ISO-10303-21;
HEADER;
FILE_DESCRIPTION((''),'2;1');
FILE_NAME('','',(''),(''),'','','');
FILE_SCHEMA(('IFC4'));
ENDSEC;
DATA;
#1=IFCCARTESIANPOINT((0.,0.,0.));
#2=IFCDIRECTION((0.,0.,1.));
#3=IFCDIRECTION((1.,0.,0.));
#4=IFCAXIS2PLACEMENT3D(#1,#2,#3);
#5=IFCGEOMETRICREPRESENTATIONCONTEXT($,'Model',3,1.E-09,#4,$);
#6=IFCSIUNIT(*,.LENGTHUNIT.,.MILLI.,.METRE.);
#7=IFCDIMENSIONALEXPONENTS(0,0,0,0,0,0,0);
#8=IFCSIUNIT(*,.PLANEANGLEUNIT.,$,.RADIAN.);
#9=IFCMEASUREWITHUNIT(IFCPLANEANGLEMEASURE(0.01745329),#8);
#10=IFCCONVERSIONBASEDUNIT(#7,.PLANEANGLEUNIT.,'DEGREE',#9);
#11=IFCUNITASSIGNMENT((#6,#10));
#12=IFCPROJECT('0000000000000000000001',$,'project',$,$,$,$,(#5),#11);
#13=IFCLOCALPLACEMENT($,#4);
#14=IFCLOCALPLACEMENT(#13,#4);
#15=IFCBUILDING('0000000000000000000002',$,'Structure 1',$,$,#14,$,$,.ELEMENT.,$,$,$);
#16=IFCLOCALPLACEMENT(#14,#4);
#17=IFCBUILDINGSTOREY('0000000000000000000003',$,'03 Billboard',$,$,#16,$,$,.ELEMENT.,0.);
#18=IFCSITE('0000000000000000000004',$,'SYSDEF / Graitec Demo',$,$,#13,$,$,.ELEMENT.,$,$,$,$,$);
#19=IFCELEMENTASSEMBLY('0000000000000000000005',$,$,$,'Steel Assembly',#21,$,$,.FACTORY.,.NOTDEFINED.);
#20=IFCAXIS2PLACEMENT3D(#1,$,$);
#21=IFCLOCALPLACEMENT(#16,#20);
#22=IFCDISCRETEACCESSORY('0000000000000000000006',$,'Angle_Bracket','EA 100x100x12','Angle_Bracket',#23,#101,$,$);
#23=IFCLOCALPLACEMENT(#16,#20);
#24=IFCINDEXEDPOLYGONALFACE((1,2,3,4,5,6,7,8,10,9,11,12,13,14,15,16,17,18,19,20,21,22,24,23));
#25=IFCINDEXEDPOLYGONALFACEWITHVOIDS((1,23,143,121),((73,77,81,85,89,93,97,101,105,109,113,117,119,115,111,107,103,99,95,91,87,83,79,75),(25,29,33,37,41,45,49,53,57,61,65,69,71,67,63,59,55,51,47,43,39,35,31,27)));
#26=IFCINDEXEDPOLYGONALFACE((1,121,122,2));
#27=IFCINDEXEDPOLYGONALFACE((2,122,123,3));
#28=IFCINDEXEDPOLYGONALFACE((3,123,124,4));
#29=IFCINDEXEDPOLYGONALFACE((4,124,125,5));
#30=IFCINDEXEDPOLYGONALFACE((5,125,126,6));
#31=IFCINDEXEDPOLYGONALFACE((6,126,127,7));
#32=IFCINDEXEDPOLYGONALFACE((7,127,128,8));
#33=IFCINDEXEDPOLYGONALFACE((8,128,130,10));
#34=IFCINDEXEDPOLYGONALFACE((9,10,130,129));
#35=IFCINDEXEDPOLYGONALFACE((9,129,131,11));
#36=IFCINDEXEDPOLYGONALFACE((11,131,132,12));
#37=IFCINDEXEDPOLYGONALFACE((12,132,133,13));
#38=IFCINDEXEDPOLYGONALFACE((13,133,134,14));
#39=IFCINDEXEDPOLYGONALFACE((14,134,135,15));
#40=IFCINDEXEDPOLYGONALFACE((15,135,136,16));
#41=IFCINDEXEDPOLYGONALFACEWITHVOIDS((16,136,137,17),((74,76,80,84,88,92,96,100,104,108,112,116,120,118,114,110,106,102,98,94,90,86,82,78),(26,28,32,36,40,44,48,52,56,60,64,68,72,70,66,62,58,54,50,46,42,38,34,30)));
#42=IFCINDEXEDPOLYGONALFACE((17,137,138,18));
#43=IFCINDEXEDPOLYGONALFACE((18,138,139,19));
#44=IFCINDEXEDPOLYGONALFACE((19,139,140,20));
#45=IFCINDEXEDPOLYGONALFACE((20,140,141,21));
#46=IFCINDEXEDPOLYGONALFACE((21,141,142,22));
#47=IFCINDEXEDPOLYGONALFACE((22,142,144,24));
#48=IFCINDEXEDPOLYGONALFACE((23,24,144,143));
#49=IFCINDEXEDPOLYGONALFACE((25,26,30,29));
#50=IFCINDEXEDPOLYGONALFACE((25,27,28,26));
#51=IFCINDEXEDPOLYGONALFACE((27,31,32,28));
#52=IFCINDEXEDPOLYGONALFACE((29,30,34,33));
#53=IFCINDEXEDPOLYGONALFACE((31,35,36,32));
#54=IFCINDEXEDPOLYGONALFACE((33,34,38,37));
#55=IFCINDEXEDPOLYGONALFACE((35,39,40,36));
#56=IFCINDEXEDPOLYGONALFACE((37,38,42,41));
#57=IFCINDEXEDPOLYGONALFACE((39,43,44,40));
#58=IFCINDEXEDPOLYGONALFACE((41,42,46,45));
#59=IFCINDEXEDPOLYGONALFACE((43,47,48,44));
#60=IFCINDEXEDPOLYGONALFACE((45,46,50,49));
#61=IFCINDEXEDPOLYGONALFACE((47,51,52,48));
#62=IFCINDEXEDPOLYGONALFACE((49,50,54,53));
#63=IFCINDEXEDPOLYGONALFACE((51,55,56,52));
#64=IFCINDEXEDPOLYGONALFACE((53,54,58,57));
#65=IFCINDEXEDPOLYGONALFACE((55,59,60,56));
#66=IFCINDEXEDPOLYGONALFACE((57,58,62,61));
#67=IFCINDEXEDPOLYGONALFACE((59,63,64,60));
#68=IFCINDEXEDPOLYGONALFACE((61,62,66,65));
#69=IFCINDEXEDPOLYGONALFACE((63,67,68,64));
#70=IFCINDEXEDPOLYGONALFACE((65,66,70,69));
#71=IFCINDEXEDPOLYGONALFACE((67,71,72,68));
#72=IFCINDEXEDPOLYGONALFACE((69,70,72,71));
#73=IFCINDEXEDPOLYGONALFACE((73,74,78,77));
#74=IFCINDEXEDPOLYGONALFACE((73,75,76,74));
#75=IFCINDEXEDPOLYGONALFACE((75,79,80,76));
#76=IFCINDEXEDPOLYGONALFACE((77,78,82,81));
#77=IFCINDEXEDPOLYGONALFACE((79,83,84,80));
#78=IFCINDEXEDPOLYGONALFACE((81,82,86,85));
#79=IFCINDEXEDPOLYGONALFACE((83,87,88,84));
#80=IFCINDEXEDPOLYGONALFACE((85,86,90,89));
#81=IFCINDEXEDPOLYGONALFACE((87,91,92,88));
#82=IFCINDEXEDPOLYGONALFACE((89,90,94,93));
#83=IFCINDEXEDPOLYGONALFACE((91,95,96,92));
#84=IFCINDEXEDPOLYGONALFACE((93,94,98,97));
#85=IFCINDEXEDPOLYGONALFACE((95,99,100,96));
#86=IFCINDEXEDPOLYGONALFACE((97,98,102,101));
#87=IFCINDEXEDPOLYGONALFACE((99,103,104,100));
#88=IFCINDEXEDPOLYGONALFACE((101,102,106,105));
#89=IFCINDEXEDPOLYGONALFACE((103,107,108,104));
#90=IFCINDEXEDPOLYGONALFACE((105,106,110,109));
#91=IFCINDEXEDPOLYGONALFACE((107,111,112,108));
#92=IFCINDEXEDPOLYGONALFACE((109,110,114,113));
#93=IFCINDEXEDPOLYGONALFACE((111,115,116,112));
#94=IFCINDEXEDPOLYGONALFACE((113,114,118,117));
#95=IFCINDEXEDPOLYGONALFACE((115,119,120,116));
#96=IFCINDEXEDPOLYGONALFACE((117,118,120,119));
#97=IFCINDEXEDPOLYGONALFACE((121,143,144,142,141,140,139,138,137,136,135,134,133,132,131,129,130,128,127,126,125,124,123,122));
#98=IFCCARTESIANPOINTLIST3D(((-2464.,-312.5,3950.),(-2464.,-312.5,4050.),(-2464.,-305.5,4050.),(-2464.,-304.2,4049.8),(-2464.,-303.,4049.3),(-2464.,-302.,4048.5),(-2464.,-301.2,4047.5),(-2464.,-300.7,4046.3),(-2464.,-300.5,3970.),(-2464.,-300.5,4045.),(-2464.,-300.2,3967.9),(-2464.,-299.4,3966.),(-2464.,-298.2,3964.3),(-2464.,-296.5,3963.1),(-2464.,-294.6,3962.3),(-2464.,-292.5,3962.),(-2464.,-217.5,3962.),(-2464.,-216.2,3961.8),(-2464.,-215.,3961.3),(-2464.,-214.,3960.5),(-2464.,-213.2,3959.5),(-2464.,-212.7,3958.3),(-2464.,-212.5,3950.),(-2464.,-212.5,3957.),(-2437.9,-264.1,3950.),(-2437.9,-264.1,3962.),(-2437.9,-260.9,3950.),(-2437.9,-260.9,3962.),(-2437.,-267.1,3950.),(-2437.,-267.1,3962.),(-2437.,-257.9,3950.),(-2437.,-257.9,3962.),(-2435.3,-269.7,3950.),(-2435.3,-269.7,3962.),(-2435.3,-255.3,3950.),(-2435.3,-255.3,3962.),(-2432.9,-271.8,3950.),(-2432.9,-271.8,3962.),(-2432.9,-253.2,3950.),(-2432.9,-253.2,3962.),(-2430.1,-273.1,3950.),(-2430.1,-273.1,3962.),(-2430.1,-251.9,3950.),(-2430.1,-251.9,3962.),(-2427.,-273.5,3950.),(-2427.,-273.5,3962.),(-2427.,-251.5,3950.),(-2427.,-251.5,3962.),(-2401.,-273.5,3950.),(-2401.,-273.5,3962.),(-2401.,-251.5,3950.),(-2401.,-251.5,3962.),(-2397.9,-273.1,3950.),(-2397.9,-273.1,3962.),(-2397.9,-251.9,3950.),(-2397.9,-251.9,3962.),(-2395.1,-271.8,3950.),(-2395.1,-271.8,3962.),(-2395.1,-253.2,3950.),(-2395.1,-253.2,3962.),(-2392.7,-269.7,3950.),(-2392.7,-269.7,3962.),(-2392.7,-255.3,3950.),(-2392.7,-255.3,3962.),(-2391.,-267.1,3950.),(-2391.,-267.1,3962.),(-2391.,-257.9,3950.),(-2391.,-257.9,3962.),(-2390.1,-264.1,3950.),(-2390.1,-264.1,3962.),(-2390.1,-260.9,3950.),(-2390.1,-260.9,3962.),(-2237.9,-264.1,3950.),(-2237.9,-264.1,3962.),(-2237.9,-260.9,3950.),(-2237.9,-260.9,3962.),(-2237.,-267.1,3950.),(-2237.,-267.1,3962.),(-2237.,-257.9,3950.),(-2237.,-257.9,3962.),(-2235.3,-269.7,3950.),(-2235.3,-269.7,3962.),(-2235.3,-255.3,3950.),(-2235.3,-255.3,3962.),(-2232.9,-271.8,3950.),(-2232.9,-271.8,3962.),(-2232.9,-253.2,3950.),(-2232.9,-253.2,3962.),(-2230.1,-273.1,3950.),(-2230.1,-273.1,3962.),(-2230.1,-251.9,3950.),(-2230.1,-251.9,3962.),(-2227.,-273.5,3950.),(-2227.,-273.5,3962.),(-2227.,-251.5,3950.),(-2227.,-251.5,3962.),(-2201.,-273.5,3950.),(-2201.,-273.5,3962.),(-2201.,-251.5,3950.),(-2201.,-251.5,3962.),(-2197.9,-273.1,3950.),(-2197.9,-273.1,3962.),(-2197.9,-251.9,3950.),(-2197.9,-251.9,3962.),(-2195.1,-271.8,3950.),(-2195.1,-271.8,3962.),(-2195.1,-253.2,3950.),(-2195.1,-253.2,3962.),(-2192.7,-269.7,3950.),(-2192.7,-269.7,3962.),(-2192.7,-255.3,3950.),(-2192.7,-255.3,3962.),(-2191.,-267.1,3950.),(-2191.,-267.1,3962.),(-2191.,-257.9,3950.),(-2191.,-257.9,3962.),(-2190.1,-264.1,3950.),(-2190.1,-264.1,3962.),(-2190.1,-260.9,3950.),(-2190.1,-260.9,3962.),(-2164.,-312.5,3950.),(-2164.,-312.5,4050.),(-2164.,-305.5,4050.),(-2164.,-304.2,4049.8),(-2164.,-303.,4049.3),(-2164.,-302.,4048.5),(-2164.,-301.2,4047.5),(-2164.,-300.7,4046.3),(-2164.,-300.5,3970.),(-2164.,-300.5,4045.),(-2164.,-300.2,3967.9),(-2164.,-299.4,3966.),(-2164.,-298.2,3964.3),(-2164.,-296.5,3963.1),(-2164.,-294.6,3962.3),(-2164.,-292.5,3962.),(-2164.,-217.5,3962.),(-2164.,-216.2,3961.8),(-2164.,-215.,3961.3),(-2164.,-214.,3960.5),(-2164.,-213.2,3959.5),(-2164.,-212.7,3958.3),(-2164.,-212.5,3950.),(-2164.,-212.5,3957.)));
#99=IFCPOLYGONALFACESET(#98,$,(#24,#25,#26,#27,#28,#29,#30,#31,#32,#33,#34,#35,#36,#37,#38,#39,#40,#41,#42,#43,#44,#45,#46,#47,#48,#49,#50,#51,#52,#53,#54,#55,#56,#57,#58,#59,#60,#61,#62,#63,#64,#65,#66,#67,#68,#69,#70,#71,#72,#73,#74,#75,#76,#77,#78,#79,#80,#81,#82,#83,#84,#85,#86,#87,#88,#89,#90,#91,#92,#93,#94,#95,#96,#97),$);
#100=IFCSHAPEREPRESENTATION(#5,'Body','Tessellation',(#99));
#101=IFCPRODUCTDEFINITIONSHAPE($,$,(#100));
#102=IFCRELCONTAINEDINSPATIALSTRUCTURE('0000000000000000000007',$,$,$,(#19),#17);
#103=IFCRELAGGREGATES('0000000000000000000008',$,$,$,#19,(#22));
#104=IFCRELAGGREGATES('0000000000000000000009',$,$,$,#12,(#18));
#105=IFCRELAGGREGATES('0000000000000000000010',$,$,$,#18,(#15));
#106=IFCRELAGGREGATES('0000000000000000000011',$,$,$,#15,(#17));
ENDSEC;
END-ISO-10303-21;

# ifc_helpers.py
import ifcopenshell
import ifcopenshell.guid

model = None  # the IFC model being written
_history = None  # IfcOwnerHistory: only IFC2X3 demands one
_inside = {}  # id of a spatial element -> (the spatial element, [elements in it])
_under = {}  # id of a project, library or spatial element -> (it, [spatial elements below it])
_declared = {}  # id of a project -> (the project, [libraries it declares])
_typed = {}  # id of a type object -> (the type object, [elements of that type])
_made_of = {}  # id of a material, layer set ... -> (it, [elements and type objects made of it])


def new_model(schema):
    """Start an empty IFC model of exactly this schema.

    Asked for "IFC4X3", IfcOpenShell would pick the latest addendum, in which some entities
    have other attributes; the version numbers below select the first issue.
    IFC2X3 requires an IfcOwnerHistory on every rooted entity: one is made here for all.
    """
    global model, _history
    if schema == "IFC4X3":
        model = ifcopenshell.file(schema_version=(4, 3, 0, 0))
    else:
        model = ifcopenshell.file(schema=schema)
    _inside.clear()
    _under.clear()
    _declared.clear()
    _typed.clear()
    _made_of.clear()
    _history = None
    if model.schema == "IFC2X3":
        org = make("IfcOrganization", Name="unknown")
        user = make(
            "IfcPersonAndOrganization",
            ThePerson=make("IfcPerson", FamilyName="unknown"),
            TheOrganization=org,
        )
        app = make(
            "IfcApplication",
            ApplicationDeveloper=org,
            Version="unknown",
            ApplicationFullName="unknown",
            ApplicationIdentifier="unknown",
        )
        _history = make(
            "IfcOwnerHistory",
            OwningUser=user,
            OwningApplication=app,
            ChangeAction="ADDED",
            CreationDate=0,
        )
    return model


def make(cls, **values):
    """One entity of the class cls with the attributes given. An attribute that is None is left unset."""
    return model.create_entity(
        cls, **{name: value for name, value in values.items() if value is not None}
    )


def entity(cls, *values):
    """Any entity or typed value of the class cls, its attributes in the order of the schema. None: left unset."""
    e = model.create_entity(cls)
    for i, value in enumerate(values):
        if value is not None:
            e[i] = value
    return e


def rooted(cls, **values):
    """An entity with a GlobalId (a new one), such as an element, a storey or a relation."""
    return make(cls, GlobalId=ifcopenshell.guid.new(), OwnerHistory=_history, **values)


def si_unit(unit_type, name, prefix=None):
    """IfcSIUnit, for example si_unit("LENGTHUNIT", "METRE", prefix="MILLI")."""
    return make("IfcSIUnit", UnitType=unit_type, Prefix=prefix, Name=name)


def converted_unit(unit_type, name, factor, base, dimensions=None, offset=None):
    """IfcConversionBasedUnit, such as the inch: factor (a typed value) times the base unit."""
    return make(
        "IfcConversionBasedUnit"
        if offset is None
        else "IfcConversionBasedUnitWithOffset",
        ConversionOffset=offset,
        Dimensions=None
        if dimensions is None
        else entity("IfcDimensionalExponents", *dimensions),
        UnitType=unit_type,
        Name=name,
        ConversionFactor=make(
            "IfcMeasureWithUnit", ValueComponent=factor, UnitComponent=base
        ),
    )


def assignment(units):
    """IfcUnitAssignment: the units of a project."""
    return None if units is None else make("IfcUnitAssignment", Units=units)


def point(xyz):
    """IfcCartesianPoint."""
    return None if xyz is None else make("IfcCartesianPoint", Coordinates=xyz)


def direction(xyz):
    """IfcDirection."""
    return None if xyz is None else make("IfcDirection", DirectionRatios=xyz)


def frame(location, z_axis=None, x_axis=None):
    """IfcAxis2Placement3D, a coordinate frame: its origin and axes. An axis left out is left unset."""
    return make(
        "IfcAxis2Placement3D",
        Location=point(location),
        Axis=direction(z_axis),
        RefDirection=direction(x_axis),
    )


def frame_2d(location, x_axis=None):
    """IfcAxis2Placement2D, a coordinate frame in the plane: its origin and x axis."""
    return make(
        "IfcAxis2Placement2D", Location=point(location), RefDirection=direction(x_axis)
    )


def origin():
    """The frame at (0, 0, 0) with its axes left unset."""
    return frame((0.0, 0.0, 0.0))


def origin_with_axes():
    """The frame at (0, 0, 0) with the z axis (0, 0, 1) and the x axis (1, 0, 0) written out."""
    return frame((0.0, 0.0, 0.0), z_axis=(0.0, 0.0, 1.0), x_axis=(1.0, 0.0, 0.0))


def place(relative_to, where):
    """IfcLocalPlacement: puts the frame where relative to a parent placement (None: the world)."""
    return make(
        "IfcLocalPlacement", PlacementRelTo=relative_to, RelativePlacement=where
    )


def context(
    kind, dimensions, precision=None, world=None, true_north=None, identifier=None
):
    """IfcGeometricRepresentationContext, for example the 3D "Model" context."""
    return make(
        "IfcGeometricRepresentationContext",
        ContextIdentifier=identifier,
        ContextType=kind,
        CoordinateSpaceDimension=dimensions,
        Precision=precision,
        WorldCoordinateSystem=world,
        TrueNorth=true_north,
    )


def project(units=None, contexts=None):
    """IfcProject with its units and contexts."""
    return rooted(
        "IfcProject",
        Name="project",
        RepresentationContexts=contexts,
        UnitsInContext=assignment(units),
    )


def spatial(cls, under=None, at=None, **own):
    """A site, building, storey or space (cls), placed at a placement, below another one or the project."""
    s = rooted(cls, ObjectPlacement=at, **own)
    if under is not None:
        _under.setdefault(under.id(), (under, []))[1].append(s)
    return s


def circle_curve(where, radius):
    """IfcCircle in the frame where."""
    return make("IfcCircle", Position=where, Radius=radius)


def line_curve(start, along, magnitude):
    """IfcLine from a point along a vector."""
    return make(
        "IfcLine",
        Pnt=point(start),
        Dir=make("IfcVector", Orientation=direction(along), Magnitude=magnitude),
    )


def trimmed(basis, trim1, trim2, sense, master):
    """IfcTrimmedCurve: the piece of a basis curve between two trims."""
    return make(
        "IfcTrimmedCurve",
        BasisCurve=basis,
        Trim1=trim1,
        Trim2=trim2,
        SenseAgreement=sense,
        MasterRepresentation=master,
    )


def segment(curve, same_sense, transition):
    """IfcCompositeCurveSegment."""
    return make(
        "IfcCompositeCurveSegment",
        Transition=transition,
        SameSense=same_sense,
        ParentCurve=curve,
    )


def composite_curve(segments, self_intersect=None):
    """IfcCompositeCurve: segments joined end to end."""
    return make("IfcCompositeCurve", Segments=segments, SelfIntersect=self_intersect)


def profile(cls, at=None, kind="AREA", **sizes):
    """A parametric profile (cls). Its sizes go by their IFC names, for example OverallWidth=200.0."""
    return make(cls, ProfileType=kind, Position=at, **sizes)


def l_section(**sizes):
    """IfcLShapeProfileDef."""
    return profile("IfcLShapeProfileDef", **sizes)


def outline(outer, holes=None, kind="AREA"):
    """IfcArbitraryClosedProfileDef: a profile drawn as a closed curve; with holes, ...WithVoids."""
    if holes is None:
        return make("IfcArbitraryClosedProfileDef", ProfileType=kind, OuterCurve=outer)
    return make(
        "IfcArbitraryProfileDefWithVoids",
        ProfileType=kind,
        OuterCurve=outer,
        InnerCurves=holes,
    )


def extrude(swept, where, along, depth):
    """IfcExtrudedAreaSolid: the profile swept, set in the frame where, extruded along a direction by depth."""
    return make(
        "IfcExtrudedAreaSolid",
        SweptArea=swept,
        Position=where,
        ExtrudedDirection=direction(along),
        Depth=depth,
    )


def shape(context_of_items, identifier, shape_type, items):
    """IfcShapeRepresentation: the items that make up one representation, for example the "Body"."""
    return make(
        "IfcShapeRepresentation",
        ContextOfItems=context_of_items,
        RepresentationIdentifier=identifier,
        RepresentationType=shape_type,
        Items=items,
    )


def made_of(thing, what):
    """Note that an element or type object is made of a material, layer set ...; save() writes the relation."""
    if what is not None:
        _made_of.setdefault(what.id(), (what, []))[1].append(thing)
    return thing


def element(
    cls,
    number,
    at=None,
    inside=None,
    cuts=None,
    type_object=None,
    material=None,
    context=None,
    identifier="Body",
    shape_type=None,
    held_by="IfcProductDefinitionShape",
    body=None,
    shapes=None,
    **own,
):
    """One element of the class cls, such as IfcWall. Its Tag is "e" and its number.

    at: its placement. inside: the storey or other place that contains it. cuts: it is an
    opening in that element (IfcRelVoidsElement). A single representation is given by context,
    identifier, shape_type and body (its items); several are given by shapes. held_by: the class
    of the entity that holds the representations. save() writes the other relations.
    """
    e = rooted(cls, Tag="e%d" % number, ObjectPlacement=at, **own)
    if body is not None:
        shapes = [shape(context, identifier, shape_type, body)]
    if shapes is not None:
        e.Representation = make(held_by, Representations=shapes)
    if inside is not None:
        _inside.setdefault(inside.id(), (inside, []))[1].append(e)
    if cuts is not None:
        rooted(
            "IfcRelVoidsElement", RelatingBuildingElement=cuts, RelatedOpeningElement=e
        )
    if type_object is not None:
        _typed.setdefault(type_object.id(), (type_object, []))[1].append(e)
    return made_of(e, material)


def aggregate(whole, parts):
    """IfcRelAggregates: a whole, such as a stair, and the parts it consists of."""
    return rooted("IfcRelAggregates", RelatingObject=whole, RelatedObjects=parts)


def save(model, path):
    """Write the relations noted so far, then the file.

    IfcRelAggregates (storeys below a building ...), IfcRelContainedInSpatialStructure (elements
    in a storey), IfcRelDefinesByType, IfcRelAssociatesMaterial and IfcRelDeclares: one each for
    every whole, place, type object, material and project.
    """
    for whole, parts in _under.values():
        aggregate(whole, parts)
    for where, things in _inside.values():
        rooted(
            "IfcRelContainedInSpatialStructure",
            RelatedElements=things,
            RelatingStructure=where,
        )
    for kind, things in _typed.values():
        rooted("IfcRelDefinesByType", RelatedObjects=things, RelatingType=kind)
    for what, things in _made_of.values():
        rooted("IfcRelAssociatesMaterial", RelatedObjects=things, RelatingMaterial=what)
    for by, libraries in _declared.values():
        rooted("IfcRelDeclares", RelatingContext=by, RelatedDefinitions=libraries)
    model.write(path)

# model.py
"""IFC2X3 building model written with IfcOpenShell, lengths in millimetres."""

from ifc_helpers import new_model, entity, si_unit, converted_unit, point, frame, frame_2d, origin, origin_with_axes, place, context, project, spatial, circle_curve, line_curve, trimmed, segment, composite_curve, l_section, outline, extrude, element, aggregate, save


model = new_model("IFC2X3")

# Units and contexts
model_context = context("Model", 3, precision=1e-09, world=origin_with_axes())
ifc_project = project(units=[si_unit("LENGTHUNIT", "METRE", prefix="MILLI"), converted_unit("PLANEANGLEUNIT", "DEGREE", entity("IfcPlaneAngleMeasure", 0.01745329), si_unit("PLANEANGLEUNIT", "RADIAN"), dimensions=[0, 0, 0, 0, 0, 0, 0])], contexts=[model_context])

# Site, building, storey
site_placement = place(None, origin_with_axes())
site = spatial("IfcSite", under=ifc_project, at=site_placement, Name="SYSDEF / Graitec Demo", CompositionType="ELEMENT")
building_placement = place(site_placement, origin_with_axes())
building = spatial("IfcBuilding", under=site, at=building_placement, Name="Structure 1", CompositionType="ELEMENT")
storey_placement = place(building_placement, origin_with_axes())
storey = spatial("IfcBuildingStorey", under=building, at=storey_placement, Name="03 Billboard", CompositionType="ELEMENT", Elevation=0.0)

# Element assembly, discrete accessory, openings
assembly_1_placement = place(None, frame((-4239.1, -387.5, 4000.0), z_axis=(-1.0, 0.0, 0.0), x_axis=(0.0, 0.0, 1.0)))
assembly_1 = element("IfcElementAssembly", 1, at=assembly_1_placement, inside=storey, ObjectType="Steel Assembly", AssemblyPlace="FACTORY", PredefinedType="NOTDEFINED")
discrete_accessory_1_placement = place(assembly_1_placement, frame((-20.8, 104.2, -2075.1), z_axis=(0.0, 0.0, -1.0), x_axis=(0.0, 1.0, 0.0)))
discrete_accessory_1 = element("IfcDiscreteAccessory", 2, at=discrete_accessory_1_placement, Name="Angle_Bracket", Description="EA 100x100x12", ObjectType="Angle_Bracket", context=model_context, shape_type="SweptSolid", body=[
    extrude(l_section(Depth=100.0, Width=100.0, Thickness=12.0, FilletRadius=8.0, EdgeRadius=5.0, at=frame_2d((20.8, 20.8))), origin(), (0.0, 0.0, -1.0), 300.0),
])
opening_1_placement = place(discrete_accessory_1_placement, frame((20.8, -16.7, -150.0), z_axis=(0.0, -1.0, 0.0), x_axis=(0.0, 0.0, -1.0)))
element("IfcOpeningElement", 3, at=opening_1_placement, cuts=discrete_accessory_1, ObjectType="Opening", context=model_context, shape_type="SweptSolid", body=[
    extrude(outline(composite_curve([segment(trimmed(line_curve((87.0, -11.0), (1.0, 0.0), 26.0), [point((87.0, -11.0))], [point((113.0, -11.0))], True, "CARTESIAN"), True, "CONTINUOUS"), segment(trimmed(circle_curve(frame_2d((113.0, 0.0), x_axis=(1.0, 0.0)), 11.0), [point((113.0, -11.0))], [point((113.0, 11.0))], True, "CARTESIAN"), True, "CONTINUOUS"), segment(trimmed(line_curve((113.0, 11.0), (-1.0, 0.0), 26.0), [point((113.0, 11.0))], [point((87.0, 11.0))], True, "CARTESIAN"), True, "CONTINUOUS"), segment(trimmed(circle_curve(frame_2d((87.0, 0.0), x_axis=(1.0, 0.0)), 11.0), [point((87.0, 11.0))], [point((87.0, -11.0))], True, "CARTESIAN"), True, "CONTINUOUS")], self_intersect=False)), origin(), (0.0, 0.0, 1.0), 13.0),
])
opening_2_placement = place(discrete_accessory_1_placement, frame((20.8, -16.7, -150.0), z_axis=(0.0, -1.0, 0.0), x_axis=(0.0, 0.0, -1.0)))
element("IfcOpeningElement", 4, at=opening_2_placement, cuts=discrete_accessory_1, ObjectType="Opening", context=model_context, shape_type="SweptSolid", body=[
    extrude(outline(composite_curve([segment(trimmed(line_curve((-113.0, -11.0), (1.0, 0.0), 26.0), [point((-113.0, -11.0))], [point((-87.0, -11.0))], True, "CARTESIAN"), True, "CONTINUOUS"), segment(trimmed(circle_curve(frame_2d((-87.0, 0.0), x_axis=(1.0, 0.0)), 11.0), [point((-87.0, -11.0))], [point((-87.0, 11.0))], True, "CARTESIAN"), True, "CONTINUOUS"), segment(trimmed(line_curve((-87.0, 11.0), (-1.0, 0.0), 26.0), [point((-87.0, 11.0))], [point((-113.0, 11.0))], True, "CARTESIAN"), True, "CONTINUOUS"), segment(trimmed(circle_curve(frame_2d((-113.0, 0.0), x_axis=(1.0, 0.0)), 11.0), [point((-113.0, 11.0))], [point((-113.0, -11.0))], True, "CARTESIAN"), True, "CONTINUOUS")], self_intersect=False)), origin(), (0.0, 0.0, 1.0), 13.0),
])
aggregate(assembly_1, [discrete_accessory_1])

save(model, "model.ifc")
